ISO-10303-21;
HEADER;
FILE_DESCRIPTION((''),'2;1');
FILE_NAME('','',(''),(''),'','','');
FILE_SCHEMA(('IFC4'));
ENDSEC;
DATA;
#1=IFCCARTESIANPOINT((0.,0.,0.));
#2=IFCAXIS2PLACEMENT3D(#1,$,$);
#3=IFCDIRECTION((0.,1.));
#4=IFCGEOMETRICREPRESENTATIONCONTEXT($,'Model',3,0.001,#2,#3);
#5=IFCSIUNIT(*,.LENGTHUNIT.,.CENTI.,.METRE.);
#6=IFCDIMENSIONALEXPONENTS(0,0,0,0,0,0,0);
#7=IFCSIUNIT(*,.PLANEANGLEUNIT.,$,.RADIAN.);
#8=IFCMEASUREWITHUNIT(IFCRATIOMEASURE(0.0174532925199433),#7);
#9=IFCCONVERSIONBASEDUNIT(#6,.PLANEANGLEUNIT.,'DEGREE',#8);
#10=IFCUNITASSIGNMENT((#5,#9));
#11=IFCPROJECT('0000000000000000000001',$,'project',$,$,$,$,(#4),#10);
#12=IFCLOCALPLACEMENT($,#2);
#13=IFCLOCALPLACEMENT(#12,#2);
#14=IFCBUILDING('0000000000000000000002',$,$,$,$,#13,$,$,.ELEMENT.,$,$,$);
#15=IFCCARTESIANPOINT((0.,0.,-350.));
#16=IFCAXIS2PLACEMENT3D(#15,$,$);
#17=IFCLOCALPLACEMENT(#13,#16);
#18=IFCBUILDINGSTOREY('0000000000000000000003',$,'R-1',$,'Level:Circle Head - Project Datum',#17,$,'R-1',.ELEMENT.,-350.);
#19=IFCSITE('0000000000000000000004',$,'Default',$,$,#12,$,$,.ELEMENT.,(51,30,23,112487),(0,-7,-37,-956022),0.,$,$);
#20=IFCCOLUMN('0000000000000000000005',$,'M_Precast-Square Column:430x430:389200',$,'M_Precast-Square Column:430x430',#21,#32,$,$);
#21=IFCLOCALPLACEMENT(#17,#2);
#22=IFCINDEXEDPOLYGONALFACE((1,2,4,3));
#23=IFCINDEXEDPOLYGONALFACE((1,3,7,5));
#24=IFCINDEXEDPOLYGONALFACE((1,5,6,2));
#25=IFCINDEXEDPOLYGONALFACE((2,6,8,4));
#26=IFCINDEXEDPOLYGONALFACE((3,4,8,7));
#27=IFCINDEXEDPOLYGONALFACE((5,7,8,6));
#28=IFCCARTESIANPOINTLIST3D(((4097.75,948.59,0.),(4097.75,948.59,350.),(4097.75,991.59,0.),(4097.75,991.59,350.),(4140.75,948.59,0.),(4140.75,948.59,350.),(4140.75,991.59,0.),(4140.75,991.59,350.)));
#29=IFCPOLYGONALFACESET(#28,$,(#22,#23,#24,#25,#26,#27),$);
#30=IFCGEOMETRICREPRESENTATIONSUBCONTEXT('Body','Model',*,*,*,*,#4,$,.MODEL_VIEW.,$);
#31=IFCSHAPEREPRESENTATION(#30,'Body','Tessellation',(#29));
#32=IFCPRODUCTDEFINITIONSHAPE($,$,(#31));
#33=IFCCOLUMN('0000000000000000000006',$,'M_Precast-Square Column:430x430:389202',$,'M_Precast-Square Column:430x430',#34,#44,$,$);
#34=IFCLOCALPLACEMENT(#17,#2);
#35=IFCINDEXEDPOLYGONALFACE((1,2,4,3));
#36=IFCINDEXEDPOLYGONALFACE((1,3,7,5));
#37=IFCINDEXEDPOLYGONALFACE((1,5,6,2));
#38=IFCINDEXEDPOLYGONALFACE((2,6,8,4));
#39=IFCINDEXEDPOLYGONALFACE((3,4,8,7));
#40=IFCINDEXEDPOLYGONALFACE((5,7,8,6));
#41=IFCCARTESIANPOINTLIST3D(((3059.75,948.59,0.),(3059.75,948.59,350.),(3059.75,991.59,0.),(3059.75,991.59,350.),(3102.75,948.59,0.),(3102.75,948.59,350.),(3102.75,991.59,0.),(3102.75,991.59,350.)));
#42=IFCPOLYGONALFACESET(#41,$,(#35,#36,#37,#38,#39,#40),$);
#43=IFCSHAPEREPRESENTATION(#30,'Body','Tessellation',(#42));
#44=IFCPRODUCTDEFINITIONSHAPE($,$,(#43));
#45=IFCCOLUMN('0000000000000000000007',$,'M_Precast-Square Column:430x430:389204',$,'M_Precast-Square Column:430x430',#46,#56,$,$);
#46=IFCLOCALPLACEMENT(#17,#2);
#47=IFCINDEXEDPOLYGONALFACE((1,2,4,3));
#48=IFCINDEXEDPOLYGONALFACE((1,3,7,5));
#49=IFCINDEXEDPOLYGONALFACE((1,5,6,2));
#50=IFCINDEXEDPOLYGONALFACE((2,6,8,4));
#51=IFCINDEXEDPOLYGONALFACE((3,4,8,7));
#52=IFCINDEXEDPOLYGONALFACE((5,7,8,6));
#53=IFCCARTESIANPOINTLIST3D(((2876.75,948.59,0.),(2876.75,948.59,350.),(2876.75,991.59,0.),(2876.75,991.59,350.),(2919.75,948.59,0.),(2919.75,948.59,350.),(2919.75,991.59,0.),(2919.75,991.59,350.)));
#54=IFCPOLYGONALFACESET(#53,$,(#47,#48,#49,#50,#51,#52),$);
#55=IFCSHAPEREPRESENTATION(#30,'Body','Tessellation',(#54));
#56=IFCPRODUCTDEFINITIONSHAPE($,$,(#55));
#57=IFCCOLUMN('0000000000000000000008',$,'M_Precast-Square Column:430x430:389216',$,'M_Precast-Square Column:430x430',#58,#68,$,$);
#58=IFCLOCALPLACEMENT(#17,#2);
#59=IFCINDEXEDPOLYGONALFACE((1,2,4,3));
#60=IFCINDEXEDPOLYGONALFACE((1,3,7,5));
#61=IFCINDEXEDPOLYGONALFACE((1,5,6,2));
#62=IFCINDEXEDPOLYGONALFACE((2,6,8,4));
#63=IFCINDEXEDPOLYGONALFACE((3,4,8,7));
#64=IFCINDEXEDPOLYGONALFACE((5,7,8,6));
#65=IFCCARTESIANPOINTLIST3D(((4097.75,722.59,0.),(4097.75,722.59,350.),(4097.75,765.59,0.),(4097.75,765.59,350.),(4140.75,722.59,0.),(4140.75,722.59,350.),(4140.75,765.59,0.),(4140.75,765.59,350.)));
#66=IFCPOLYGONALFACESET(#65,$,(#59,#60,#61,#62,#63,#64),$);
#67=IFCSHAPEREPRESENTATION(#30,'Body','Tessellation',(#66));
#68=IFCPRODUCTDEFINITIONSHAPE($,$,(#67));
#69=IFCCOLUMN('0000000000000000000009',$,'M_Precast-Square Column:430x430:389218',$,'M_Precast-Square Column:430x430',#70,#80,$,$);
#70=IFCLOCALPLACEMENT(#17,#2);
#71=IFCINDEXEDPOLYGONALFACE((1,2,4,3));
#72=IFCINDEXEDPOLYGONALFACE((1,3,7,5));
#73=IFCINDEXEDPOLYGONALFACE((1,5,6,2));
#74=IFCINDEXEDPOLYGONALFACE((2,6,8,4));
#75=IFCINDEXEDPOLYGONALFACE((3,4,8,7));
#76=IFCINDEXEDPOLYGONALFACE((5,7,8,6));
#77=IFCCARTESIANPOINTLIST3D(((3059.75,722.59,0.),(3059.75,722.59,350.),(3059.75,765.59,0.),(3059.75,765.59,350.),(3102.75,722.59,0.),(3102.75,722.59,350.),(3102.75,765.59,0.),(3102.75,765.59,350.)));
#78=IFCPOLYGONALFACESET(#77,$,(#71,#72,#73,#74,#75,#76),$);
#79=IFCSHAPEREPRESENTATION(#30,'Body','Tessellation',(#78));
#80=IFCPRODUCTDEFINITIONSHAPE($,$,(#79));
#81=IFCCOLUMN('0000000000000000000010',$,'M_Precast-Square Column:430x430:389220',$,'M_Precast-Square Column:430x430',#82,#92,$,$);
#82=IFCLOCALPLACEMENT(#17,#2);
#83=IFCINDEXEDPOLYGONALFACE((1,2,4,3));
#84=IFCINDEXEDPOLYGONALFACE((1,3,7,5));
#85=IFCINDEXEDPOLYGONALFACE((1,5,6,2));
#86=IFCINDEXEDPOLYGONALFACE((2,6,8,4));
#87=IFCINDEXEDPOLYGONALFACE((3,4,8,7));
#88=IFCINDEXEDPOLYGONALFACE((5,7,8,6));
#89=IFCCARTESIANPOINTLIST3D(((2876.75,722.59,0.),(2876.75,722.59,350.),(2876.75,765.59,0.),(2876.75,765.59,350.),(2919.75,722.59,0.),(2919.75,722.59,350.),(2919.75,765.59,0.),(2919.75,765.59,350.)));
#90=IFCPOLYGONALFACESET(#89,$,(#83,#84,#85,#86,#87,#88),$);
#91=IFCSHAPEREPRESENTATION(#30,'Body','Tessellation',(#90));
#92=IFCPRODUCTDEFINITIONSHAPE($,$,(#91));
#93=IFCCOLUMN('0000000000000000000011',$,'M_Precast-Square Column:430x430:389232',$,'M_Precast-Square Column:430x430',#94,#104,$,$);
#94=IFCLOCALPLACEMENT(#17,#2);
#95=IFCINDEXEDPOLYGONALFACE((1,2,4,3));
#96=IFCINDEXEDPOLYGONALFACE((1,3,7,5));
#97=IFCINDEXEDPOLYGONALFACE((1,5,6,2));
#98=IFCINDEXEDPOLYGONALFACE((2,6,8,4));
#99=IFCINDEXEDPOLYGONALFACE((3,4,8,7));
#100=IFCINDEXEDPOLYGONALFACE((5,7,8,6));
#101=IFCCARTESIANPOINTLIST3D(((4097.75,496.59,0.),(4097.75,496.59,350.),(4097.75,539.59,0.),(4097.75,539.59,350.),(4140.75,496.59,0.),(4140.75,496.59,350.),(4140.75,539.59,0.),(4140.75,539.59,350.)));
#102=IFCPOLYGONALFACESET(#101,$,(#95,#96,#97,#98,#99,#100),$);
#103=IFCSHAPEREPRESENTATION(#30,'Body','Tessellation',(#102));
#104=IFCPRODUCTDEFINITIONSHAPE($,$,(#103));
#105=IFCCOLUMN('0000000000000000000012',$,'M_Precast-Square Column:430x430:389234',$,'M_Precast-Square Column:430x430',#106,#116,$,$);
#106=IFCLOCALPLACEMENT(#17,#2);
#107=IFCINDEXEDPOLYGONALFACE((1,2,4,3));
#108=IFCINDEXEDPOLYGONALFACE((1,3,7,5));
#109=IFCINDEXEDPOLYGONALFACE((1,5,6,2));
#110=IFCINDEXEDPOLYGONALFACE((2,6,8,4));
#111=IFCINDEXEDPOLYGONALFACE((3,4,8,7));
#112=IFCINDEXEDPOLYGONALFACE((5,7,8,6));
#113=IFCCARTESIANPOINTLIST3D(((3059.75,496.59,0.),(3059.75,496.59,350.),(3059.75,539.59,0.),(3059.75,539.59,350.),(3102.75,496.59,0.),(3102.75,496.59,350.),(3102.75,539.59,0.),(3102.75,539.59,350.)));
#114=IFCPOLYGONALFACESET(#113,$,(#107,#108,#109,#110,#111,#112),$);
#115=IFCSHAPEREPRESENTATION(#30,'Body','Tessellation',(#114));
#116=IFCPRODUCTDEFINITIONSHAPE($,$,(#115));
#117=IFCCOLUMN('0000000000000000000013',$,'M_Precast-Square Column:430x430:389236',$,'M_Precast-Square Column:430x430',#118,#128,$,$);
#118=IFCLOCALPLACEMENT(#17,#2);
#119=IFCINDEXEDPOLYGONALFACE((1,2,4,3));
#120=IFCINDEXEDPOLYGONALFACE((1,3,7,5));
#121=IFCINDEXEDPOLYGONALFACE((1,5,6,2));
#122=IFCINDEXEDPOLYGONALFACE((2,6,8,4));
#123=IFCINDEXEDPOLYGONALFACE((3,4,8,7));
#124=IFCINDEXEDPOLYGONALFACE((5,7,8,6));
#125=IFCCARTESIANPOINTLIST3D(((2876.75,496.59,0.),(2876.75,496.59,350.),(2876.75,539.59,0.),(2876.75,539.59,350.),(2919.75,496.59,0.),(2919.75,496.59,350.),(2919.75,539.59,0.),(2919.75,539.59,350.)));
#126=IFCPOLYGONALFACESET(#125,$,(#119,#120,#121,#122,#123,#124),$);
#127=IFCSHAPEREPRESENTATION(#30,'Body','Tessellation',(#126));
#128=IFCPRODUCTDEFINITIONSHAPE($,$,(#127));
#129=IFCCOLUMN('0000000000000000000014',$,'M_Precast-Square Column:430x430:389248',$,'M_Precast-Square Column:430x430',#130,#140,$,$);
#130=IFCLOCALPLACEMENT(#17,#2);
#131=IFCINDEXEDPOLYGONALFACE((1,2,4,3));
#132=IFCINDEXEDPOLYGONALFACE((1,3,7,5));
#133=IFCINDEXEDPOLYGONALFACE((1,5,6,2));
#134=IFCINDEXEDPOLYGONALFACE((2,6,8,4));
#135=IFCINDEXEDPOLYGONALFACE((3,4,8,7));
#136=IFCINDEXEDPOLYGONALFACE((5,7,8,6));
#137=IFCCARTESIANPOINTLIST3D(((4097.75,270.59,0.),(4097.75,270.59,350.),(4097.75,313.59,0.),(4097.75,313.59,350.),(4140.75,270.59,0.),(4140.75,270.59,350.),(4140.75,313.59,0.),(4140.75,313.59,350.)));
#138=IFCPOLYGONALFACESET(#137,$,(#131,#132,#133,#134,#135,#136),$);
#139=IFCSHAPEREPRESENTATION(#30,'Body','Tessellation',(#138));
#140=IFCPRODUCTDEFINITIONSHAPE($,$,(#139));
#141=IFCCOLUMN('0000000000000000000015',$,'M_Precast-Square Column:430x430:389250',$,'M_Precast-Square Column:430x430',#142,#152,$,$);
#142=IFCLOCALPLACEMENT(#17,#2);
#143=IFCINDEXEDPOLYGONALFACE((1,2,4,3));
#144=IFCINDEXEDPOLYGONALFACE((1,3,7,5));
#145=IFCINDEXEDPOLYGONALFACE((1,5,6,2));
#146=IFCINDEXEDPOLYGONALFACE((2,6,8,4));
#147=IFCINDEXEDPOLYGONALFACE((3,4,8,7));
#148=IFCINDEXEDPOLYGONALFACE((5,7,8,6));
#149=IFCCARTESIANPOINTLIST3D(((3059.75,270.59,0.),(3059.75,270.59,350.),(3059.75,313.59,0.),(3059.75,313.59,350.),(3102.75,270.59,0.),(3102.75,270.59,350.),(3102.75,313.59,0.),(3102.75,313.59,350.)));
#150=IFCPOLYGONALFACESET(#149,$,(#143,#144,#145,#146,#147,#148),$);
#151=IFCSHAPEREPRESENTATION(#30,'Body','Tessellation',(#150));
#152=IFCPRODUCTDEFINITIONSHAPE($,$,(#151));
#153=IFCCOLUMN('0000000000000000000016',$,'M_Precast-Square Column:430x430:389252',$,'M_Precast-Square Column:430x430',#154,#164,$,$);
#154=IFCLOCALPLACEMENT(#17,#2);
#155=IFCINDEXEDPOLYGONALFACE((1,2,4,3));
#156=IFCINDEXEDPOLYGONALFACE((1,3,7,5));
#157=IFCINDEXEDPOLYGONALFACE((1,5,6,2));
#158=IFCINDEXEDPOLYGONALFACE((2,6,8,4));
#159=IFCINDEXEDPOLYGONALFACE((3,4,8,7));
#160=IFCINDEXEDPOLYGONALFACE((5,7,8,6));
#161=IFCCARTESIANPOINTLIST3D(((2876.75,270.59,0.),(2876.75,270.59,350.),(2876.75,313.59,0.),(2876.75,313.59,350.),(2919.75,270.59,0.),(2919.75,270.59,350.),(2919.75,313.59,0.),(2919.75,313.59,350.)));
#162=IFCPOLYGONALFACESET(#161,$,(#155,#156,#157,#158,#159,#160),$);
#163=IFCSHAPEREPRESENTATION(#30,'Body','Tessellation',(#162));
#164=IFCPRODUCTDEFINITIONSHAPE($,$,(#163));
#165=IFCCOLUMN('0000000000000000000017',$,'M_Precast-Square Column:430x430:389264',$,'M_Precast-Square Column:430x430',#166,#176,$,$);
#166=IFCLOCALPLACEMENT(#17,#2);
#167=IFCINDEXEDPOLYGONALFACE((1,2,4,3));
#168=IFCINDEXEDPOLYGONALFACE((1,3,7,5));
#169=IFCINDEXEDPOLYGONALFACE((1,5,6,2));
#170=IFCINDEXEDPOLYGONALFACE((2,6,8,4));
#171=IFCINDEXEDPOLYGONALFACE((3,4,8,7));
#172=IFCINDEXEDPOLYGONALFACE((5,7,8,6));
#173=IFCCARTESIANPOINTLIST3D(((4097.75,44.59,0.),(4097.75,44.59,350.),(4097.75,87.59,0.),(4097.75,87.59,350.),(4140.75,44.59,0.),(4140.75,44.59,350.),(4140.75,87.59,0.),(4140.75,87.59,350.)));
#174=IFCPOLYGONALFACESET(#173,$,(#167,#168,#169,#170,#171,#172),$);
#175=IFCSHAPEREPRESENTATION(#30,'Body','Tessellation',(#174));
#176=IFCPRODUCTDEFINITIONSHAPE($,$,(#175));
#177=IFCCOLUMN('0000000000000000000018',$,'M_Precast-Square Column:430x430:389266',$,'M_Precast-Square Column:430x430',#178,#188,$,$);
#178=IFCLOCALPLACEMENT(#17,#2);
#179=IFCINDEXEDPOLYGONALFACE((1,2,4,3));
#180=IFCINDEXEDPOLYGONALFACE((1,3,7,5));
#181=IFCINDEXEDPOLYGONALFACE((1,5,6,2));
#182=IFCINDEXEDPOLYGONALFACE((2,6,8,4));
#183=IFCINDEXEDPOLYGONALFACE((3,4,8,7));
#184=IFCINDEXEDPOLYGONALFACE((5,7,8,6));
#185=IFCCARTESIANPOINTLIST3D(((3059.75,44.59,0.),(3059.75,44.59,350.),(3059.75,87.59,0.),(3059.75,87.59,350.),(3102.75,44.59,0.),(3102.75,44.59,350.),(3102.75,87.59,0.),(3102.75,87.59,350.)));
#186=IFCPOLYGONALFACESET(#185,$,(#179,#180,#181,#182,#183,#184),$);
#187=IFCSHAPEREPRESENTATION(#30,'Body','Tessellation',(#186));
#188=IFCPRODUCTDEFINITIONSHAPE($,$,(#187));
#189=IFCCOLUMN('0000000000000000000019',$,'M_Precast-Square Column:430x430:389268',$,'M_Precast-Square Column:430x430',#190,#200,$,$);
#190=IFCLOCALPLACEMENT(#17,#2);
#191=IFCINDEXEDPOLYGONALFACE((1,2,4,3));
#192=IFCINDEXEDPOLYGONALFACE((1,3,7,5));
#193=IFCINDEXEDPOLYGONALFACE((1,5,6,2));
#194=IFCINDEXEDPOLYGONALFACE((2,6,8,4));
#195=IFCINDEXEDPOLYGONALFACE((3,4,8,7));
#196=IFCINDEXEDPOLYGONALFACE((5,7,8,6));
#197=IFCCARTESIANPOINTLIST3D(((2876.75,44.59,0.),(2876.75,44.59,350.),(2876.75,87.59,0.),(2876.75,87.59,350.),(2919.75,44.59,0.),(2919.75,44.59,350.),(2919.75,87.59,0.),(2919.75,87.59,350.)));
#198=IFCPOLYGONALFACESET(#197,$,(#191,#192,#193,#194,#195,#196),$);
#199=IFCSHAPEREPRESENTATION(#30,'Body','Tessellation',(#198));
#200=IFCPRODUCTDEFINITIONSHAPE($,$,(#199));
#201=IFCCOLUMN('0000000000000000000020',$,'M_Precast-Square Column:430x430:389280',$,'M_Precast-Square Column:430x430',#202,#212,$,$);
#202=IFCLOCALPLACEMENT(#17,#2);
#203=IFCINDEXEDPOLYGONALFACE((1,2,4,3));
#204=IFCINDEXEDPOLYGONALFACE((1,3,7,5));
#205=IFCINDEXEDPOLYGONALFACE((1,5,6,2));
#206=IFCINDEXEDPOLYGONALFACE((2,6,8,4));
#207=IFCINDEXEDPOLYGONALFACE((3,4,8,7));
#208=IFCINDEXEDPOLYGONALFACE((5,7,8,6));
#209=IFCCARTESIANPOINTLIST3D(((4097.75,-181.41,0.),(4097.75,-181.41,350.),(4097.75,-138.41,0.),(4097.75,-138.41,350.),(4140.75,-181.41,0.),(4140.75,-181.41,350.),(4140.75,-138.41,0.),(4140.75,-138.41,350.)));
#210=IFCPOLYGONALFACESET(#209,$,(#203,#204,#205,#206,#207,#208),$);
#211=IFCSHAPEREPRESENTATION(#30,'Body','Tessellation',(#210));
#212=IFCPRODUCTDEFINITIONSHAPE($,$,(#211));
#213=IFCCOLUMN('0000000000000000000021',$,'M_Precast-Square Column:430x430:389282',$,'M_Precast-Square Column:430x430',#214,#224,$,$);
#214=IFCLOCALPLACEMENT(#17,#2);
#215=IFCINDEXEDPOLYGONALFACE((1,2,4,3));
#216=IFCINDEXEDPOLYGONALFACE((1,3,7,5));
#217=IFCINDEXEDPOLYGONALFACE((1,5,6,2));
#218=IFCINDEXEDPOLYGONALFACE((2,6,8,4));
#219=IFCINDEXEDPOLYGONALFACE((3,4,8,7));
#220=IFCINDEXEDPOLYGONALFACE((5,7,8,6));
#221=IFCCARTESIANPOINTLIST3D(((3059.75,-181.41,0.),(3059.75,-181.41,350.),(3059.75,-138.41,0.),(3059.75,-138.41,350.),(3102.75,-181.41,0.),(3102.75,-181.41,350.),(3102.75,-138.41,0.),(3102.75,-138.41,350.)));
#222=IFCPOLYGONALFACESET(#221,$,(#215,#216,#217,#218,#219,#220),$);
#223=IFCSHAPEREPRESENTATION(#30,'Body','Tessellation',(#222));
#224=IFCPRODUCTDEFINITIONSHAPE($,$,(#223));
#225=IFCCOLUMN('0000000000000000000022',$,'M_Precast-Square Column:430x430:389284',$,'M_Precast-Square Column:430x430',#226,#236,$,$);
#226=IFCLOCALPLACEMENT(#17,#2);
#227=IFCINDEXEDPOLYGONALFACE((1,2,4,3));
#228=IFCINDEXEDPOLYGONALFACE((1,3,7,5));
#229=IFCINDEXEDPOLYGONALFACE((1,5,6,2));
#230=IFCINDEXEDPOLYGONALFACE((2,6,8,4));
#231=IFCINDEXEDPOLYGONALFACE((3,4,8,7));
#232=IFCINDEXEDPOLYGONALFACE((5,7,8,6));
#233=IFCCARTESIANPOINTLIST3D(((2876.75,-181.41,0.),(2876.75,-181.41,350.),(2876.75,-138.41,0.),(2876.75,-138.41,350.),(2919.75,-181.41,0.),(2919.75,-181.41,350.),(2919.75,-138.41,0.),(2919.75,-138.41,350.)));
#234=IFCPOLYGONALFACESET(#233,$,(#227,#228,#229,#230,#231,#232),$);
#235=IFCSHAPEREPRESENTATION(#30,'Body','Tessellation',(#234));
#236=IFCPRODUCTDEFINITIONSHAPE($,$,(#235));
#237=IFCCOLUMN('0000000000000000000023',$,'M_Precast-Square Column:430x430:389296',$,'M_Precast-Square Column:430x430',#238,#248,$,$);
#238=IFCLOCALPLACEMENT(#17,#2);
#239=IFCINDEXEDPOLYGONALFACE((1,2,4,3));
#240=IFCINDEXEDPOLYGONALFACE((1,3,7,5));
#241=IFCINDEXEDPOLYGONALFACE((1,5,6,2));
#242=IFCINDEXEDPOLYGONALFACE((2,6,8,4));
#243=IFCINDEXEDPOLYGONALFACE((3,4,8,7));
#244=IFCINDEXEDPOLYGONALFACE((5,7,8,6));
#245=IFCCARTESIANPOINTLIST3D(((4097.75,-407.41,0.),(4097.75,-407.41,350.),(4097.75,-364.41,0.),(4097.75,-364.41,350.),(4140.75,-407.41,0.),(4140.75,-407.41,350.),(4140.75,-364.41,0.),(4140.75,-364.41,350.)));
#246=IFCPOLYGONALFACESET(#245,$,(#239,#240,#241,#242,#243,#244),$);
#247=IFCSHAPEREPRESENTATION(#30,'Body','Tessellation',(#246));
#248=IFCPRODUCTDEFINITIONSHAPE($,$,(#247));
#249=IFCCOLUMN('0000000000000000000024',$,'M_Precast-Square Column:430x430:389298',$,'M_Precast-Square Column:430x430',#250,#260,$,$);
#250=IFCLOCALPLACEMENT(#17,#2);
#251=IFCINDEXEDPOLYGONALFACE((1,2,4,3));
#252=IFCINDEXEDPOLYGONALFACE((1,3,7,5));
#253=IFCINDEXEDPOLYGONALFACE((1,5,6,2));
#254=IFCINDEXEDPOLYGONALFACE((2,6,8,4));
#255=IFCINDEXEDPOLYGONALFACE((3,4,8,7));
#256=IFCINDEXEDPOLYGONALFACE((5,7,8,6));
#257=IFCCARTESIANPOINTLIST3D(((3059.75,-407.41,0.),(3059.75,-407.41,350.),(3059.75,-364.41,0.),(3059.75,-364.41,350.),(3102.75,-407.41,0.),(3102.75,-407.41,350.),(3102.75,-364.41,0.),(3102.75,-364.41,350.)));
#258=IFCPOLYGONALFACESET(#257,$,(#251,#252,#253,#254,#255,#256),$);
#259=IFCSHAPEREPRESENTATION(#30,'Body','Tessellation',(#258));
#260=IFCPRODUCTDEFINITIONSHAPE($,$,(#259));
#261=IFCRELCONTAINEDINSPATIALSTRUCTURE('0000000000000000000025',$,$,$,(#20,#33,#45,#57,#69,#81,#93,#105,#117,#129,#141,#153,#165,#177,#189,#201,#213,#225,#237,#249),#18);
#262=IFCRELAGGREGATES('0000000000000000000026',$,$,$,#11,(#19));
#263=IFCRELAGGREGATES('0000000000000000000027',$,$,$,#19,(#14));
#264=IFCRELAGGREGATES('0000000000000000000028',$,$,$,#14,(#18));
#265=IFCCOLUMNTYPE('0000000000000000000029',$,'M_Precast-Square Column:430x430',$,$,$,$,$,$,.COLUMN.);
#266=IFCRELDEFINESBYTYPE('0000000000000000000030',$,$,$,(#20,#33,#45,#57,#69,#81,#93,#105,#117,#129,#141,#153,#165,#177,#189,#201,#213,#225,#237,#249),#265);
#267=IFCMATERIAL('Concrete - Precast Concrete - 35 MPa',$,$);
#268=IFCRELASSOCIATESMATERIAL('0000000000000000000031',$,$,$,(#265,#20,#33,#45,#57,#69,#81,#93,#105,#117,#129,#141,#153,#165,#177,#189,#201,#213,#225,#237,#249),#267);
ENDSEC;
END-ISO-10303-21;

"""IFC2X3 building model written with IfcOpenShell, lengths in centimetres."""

from ifc_helpers import new_model, entity, si_unit, converted_unit, direction, frame, origin, origin_2d_with_axis, place, context, subcontext, project, spatial, rectangle, extrude, source, transform, mapped, material, type_object, type_shapes, element, save


model = new_model("IFC2X3")

# Units and contexts
model_context = context("Model", 3, precision=0.001, world=origin(), true_north=direction((0.0, 1.0)))
body_context = subcontext(model_context, "Body", "Model", "MODEL_VIEW")
ifc_project = project(units=[si_unit("LENGTHUNIT", "METRE", prefix="CENTI"), converted_unit("PLANEANGLEUNIT", "DEGREE", entity("IfcRatioMeasure", 0.0174532925199433), si_unit("PLANEANGLEUNIT", "RADIAN"), dimensions=[0, 0, 0, 0, 0, 0, 0])], contexts=[model_context])

# Site, building, storey
site_placement = place(None, origin())
site = spatial("IfcSite", under=ifc_project, at=site_placement, Name="Default", CompositionType="ELEMENT", RefLatitude=(51, 30, 23, 112487), RefLongitude=(0, -7, -37, -956022), RefElevation=0.0)
building_placement = place(site_placement, origin())
building = spatial("IfcBuilding", under=site, at=building_placement, CompositionType="ELEMENT")
storey_placement = place(building_placement, frame((0.0, 0.0, -350.0)))
storey = spatial("IfcBuildingStorey", under=building, at=storey_placement, Name="R-1", ObjectType="Level:Circle Head - Project Datum", LongName="R-1", CompositionType="ELEMENT", Elevation=-350.0)

# Columns
ifc_material_1 = material(Name="Concrete - Precast Concrete - 35 MPa")
column_type = type_object("IfcColumnType", Name="M_Precast-Square Column:430x430", PredefinedType="COLUMN", material=ifc_material_1)
shared_shape = source(origin(), body_context, "Body", "SweptSolid", [
    extrude(rectangle(XDim=43.0, YDim=43.0, at=origin_2d_with_axis()), frame((0.0, 0.0, -350.0), z_axis=(0.0, 0.0, 1.0), x_axis=(0.0, -1.0, 0.0)), (0.0, 0.0, 1.0), 350.0),
])
type_shapes(column_type, [shared_shape])
for number, where, name in (
    (1, (4119.25, 970.09, 350.0), "M_Precast-Square Column:430x430:389200"),
    (2, (3081.25, 970.09, 350.0), "M_Precast-Square Column:430x430:389202"),
    (3, (2898.25, 970.09, 350.0), "M_Precast-Square Column:430x430:389204"),
    (4, (4119.25, 744.09, 350.0), "M_Precast-Square Column:430x430:389216"),
    (5, (3081.25, 744.09, 350.0), "M_Precast-Square Column:430x430:389218"),
    (6, (2898.25, 744.09, 350.0), "M_Precast-Square Column:430x430:389220"),
    (7, (4119.25, 518.09, 350.0), "M_Precast-Square Column:430x430:389232"),
    (8, (3081.25, 518.09, 350.0), "M_Precast-Square Column:430x430:389234"),
    (9, (2898.25, 518.09, 350.0), "M_Precast-Square Column:430x430:389236"),
    (10, (4119.25, 292.09, 350.0), "M_Precast-Square Column:430x430:389248"),
    (11, (3081.25, 292.09, 350.0), "M_Precast-Square Column:430x430:389250"),
    (12, (2898.25, 292.09, 350.0), "M_Precast-Square Column:430x430:389252"),
    (13, (4119.25, 66.09, 350.0), "M_Precast-Square Column:430x430:389264"),
    (14, (3081.25, 66.09, 350.0), "M_Precast-Square Column:430x430:389266"),
    (15, (2898.25, 66.09, 350.0), "M_Precast-Square Column:430x430:389268"),
    (16, (4119.25, -159.91, 350.0), "M_Precast-Square Column:430x430:389280"),
    (17, (3081.25, -159.91, 350.0), "M_Precast-Square Column:430x430:389282"),
    (18, (2898.25, -159.91, 350.0), "M_Precast-Square Column:430x430:389284"),
    (19, (4119.25, -385.91, 350.0), "M_Precast-Square Column:430x430:389296"),
    (20, (3081.25, -385.91, 350.0), "M_Precast-Square Column:430x430:389298"),
):
    element("IfcColumn", number, at=place(storey_placement, frame(where)), inside=storey, type_object=column_type, material=ifc_material_1, Name=name, ObjectType="M_Precast-Square Column:430x430", context=body_context, shape_type="MappedRepresentation", body=[
        mapped(shared_shape, transform((0.0, 0.0, 0.0), scale=1.0)),
    ])

save(model, "model.ifc")
